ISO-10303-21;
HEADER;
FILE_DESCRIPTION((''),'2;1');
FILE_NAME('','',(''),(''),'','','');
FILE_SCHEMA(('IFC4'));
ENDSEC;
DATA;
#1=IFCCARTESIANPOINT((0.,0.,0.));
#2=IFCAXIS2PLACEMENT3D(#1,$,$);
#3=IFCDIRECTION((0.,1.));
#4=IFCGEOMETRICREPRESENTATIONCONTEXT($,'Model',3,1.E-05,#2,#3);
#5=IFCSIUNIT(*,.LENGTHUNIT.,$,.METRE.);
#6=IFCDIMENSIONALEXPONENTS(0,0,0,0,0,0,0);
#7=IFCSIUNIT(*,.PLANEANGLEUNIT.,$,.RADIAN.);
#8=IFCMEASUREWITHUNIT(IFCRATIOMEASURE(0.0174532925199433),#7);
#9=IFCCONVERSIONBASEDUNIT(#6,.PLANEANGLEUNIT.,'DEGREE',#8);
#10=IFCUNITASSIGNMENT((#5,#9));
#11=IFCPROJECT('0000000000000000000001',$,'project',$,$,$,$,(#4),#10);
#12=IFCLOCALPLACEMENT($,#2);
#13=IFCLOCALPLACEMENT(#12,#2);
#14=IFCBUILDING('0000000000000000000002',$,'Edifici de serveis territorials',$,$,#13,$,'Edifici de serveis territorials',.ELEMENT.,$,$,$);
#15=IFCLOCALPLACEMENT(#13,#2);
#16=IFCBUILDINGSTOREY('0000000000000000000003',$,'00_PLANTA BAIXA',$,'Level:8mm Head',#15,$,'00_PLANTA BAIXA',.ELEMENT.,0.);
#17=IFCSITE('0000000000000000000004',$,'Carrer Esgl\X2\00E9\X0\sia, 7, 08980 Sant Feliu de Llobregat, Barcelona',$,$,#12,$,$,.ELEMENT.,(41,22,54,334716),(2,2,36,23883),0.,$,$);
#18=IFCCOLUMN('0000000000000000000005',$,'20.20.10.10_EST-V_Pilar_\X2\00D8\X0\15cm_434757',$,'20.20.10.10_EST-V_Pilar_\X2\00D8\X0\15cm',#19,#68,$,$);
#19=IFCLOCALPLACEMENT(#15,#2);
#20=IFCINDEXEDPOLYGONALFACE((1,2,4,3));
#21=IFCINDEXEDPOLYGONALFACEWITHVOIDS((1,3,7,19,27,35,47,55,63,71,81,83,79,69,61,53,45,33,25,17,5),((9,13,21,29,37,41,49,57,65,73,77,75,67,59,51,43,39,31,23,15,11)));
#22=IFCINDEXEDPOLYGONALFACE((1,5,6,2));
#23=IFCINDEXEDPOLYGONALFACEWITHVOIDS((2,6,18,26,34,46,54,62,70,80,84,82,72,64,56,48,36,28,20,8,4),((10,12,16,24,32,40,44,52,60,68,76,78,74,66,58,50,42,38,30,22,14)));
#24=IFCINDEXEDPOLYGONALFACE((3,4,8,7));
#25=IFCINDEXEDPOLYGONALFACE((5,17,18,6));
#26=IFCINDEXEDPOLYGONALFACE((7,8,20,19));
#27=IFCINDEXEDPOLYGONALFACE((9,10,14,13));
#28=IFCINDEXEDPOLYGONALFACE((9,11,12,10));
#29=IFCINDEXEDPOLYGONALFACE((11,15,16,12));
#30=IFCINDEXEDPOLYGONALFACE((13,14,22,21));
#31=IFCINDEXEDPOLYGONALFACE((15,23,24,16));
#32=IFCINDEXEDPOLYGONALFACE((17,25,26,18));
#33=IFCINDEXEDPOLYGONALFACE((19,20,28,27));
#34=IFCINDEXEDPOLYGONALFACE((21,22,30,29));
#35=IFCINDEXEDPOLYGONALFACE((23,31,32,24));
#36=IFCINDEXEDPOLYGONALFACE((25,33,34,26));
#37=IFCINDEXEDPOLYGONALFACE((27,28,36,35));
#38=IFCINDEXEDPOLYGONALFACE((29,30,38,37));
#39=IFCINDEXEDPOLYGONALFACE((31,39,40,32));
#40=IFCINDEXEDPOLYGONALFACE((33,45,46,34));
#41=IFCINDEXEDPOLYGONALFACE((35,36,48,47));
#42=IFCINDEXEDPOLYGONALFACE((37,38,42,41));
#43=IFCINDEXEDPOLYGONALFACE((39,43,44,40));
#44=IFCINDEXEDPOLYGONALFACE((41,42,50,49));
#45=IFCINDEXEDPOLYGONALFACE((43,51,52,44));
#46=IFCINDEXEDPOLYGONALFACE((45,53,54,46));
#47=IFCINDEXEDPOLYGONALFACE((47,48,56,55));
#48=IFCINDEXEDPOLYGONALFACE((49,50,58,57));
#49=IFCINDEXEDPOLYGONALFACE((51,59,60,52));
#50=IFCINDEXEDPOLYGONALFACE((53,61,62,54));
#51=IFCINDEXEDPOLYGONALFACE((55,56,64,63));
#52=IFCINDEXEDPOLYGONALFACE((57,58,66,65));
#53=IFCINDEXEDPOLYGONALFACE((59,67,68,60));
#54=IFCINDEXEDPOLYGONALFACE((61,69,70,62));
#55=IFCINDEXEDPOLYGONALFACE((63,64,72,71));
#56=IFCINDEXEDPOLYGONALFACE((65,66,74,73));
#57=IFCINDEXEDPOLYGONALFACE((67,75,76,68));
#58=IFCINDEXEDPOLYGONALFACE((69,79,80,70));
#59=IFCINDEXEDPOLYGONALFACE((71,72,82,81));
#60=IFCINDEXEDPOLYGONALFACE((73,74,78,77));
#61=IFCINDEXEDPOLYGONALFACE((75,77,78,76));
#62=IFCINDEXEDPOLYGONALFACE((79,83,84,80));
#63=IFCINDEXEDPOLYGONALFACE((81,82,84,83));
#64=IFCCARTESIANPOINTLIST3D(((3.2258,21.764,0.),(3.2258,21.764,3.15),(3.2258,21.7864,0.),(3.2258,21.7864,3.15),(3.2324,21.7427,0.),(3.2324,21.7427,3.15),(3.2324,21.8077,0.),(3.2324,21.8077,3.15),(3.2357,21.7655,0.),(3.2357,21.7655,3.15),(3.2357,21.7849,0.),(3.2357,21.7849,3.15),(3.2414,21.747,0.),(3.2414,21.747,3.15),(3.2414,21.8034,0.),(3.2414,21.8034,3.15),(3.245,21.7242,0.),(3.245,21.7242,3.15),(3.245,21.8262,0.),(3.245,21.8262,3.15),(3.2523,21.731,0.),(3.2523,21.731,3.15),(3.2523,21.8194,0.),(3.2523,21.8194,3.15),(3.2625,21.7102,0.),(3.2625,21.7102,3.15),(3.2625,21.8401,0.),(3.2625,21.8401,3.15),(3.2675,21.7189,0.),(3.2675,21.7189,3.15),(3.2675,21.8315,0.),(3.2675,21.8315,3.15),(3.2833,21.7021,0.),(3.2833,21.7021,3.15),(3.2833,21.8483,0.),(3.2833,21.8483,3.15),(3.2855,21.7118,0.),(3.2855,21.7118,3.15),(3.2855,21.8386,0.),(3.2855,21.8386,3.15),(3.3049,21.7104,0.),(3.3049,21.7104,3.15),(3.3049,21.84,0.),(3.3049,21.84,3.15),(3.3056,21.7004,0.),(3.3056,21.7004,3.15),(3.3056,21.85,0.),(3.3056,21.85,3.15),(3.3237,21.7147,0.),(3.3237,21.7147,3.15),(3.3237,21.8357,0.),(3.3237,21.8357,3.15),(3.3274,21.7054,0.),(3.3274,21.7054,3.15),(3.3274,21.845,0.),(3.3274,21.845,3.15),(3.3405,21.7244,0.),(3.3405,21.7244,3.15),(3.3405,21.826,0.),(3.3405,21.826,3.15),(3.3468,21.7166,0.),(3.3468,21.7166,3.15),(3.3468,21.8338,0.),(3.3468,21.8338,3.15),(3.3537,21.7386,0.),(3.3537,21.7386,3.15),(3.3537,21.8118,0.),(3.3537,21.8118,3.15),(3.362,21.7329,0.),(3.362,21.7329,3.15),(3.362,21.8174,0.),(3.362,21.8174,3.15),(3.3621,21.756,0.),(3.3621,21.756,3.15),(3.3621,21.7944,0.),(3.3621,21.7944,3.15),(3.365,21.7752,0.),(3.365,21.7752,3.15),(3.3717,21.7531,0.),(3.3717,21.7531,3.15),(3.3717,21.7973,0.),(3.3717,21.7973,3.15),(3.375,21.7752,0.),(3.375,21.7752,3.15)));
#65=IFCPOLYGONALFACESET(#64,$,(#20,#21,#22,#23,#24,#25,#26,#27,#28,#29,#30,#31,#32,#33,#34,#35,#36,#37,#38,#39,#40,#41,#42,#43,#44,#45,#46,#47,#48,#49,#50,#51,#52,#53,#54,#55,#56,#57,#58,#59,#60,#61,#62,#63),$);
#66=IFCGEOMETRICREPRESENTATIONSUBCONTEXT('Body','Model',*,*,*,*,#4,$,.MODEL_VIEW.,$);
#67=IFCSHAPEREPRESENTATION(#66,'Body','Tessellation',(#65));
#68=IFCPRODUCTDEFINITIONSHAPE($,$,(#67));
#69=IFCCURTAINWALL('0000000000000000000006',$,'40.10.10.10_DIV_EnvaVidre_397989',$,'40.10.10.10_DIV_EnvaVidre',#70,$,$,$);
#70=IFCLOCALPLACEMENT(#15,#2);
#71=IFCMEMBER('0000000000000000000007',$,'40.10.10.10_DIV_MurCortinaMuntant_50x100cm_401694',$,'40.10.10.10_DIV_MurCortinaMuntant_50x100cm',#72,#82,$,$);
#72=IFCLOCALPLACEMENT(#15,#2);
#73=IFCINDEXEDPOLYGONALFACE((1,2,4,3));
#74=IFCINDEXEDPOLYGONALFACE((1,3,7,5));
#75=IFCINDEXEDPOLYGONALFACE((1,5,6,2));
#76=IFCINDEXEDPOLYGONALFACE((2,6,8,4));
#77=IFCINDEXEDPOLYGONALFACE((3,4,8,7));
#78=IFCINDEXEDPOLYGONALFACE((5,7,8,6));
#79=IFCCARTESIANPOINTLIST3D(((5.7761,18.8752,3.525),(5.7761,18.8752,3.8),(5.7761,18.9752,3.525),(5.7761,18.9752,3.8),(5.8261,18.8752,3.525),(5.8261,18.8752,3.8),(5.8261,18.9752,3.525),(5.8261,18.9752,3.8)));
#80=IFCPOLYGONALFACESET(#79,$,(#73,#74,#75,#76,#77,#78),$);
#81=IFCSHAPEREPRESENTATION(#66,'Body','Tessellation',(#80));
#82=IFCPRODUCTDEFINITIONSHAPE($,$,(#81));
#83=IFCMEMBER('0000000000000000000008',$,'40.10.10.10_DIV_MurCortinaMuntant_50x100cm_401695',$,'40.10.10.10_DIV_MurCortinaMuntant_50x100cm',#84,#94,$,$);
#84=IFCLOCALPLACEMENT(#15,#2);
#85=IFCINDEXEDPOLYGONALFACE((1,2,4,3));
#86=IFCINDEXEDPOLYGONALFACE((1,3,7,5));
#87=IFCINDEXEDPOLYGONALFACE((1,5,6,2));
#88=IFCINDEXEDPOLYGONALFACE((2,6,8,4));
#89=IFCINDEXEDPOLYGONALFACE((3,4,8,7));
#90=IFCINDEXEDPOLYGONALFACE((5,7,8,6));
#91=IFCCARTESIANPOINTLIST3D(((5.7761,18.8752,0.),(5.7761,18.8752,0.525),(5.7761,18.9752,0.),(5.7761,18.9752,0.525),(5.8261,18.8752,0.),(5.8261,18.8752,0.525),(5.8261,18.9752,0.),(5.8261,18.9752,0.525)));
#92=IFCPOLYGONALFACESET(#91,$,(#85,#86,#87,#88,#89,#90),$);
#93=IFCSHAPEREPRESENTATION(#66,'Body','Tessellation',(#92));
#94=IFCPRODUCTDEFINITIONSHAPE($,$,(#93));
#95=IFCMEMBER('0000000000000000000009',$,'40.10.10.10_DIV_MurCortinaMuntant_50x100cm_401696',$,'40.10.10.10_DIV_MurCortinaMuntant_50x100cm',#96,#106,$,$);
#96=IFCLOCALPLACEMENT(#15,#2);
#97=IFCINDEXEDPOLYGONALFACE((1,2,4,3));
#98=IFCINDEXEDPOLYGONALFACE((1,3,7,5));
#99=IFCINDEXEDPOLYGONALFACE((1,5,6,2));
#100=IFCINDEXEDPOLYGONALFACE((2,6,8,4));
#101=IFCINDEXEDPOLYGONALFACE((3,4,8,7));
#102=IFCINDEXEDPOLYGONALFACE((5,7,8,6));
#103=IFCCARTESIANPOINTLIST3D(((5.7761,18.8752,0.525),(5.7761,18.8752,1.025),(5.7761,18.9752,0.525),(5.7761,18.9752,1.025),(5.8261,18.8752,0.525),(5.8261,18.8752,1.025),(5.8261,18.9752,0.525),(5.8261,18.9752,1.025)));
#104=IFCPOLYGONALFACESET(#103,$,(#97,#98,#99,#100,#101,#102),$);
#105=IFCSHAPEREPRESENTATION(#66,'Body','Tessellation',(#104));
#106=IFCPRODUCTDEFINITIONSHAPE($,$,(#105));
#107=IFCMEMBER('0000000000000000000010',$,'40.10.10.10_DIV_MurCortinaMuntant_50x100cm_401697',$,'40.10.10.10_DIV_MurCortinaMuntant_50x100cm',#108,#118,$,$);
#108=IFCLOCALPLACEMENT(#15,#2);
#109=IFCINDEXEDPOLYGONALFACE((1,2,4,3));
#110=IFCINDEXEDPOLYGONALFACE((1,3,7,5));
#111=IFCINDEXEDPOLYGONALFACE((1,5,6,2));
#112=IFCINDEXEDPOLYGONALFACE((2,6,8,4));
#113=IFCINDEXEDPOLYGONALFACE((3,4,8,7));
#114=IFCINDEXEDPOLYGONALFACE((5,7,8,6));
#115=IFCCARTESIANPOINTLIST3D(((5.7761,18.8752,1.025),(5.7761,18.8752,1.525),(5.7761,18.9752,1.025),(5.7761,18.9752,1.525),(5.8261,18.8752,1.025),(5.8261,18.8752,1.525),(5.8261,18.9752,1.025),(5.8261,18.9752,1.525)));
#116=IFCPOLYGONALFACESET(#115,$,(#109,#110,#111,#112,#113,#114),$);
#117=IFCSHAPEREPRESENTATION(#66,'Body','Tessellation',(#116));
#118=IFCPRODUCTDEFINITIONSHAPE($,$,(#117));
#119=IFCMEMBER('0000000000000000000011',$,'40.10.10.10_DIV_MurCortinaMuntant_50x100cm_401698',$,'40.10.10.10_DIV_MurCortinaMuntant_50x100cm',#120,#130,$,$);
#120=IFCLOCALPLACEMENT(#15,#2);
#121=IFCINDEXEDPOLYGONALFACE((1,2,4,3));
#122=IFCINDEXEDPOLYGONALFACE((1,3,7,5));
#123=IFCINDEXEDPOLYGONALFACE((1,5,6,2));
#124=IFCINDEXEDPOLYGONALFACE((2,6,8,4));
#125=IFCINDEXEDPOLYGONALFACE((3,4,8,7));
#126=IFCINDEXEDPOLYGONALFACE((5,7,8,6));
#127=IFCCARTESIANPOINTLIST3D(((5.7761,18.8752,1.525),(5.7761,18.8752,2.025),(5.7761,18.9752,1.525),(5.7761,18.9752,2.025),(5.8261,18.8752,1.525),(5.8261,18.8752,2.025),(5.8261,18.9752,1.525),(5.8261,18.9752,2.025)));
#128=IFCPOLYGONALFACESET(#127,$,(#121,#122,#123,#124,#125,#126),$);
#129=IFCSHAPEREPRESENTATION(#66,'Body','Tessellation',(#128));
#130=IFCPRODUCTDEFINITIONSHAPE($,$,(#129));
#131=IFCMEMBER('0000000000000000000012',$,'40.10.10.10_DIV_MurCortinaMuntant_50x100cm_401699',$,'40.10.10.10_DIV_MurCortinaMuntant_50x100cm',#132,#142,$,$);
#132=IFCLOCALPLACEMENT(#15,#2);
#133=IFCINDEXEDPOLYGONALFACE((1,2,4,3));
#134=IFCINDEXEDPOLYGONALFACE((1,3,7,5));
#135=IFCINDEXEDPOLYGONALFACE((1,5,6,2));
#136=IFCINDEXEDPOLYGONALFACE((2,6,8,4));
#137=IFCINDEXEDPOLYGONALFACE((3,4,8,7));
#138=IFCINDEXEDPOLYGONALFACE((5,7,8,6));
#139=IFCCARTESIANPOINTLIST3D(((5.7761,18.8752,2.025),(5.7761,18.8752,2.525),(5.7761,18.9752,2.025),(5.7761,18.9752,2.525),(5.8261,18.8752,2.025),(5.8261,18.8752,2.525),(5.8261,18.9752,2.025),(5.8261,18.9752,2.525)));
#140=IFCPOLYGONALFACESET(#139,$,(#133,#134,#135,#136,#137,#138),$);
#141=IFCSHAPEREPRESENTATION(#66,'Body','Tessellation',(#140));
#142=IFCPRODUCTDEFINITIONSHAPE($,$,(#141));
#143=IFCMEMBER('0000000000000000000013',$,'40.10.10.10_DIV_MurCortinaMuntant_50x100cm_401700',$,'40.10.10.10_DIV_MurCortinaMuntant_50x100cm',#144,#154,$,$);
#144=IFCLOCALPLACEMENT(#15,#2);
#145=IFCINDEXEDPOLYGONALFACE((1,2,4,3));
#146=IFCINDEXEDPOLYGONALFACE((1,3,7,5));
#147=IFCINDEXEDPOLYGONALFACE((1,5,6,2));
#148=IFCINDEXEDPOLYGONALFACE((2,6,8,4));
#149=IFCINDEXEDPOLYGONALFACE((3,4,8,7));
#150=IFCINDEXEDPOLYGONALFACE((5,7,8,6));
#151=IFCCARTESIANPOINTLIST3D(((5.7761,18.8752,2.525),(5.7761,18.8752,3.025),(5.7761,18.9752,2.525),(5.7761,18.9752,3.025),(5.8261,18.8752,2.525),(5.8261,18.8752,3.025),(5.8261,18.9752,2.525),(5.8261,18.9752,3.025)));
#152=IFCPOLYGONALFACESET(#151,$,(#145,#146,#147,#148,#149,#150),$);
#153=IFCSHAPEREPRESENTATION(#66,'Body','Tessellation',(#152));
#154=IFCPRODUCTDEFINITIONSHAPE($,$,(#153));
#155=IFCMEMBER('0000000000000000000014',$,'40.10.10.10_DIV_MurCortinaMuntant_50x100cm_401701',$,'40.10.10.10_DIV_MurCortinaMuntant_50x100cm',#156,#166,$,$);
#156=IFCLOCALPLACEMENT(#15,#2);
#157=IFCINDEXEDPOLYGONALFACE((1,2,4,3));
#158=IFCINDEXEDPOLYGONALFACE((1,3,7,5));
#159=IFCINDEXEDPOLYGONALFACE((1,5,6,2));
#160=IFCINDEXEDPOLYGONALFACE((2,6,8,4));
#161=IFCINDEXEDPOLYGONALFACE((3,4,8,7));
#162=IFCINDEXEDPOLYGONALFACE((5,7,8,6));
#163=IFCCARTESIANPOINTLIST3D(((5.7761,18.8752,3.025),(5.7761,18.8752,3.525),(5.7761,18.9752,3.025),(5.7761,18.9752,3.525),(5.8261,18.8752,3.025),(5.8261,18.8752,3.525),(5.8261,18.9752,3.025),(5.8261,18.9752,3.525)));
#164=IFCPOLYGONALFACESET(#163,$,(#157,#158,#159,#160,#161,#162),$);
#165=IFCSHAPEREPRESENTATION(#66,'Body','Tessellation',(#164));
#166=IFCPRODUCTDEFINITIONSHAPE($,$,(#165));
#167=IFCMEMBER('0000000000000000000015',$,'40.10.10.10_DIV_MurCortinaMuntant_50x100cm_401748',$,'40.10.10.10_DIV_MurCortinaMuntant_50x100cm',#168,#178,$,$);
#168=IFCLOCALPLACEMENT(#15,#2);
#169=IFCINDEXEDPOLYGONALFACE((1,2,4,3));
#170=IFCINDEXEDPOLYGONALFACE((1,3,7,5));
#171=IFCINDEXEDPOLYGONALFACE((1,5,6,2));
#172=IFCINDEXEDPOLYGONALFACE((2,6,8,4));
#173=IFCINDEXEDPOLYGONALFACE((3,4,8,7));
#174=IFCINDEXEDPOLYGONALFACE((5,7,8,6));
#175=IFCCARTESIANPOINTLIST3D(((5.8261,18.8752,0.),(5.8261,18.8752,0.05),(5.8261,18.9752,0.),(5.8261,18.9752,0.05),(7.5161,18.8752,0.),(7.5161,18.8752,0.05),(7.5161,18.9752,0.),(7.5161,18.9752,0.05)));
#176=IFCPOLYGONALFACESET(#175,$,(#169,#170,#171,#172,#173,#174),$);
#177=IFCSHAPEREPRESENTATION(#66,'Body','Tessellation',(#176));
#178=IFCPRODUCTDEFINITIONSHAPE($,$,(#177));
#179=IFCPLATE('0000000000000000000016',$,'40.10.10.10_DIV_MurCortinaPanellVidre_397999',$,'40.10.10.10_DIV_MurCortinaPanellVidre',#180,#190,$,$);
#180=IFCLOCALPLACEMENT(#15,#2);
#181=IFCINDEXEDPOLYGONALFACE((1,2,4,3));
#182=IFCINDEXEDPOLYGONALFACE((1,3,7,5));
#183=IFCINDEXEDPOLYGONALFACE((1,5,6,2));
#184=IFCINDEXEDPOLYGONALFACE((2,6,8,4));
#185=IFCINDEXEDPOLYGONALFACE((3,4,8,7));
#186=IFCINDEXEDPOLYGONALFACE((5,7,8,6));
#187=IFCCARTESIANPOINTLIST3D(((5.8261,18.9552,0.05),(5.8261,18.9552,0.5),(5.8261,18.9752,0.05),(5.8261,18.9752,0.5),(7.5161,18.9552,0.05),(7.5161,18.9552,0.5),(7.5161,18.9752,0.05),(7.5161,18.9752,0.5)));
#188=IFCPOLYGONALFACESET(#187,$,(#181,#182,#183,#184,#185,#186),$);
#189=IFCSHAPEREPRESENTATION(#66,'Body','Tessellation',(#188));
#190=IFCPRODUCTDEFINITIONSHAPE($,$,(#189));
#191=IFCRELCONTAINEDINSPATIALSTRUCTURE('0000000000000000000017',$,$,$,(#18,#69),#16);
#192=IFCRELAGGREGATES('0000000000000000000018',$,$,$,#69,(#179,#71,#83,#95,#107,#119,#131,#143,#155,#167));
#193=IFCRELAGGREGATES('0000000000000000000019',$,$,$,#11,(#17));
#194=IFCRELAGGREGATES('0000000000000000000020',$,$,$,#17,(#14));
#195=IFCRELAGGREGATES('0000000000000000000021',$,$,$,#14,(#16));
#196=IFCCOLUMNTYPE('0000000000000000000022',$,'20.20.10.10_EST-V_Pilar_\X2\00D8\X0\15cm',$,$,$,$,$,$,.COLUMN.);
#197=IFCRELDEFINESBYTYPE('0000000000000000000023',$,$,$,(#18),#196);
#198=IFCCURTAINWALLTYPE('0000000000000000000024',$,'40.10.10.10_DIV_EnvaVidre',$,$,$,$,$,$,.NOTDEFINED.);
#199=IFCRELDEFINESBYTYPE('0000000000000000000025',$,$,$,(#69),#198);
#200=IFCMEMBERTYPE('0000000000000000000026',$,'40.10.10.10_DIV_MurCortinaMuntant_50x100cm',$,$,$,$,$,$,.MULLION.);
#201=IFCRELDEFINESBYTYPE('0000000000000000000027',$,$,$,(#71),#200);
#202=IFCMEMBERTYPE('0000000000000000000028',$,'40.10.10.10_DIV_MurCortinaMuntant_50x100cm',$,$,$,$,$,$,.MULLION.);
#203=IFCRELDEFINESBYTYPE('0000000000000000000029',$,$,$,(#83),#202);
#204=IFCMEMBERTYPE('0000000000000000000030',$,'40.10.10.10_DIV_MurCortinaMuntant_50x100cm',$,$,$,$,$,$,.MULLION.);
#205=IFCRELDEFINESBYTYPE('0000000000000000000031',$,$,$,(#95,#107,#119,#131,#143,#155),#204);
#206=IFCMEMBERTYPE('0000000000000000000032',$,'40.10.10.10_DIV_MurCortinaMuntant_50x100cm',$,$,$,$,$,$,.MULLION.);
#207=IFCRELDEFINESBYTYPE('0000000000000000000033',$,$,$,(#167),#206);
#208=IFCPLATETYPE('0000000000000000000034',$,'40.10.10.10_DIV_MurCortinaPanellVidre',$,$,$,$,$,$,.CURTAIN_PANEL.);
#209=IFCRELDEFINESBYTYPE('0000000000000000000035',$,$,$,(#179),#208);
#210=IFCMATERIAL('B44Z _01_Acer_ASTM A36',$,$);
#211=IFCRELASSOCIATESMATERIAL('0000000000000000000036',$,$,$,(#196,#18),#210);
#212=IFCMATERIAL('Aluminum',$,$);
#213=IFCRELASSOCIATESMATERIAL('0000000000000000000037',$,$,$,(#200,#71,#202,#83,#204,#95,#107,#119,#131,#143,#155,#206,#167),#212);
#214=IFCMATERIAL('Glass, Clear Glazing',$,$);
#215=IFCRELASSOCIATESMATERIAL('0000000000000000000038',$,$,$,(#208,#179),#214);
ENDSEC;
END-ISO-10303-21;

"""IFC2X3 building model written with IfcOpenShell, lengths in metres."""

from ifc_helpers import new_model, entity, si_unit, converted_unit, direction, frame, frame_2d, origin, origin_2d_with_axis, place, context, subcontext, project, spatial, rectangle, hollow_circle, extrude, source, transform, mapped, material, type_object, type_shapes, element, aggregate, save


model = new_model("IFC2X3")

# Units and contexts
model_context = context("Model", 3, precision=1e-05, world=origin(), true_north=direction((0.0, 1.0)))
body_context = subcontext(model_context, "Body", "Model", "MODEL_VIEW")
ifc_project = project(units=[si_unit("LENGTHUNIT", "METRE"), converted_unit("PLANEANGLEUNIT", "DEGREE", entity("IfcRatioMeasure", 0.0174532925199433), si_unit("PLANEANGLEUNIT", "RADIAN"), dimensions=[0, 0, 0, 0, 0, 0, 0])], contexts=[model_context])

# Site, building, storey
site_placement = place(None, origin())
site = spatial("IfcSite", under=ifc_project, at=site_placement, Name="Carrer Església, 7, 08980 Sant Feliu de Llobregat, Barcelona", CompositionType="ELEMENT", RefLatitude=(41, 22, 54, 334716), RefLongitude=(2, 2, 36, 23883), RefElevation=0.0)
building_placement = place(site_placement, origin())
building = spatial("IfcBuilding", under=site, at=building_placement, Name="Edifici de serveis territorials", LongName="Edifici de serveis territorials", CompositionType="ELEMENT")
storey_placement = place(building_placement, origin())
storey = spatial("IfcBuildingStorey", under=building, at=storey_placement, Name="00_PLANTA BAIXA", ObjectType="Level:8mm Head", LongName="00_PLANTA BAIXA", CompositionType="ELEMENT", Elevation=0.0)

# Column
ifc_material_1 = material(Name="B44Z _01_Acer_ASTM A36")
column_type = type_object("IfcColumnType", Name="20.20.10.10_EST-V_Pilar_Ø15cm", PredefinedType="COLUMN", material=ifc_material_1)
shared_shape_1 = source(origin(), body_context, "Body", "SweptSolid", [
    extrude(hollow_circle(Radius=0.075, WallThickness=0.01, at=frame_2d((0.0, 0.0), x_axis=(1.0, 0.0))), origin(), (0.0, 0.0, 1.0), 3.15),
])
type_shapes(column_type, [shared_shape_1])
column_placement = place(storey_placement, frame((3.3, 21.7752, 0.0)))
element("IfcColumn", 1, at=column_placement, inside=storey, type_object=column_type, material=ifc_material_1, Name="20.20.10.10_EST-V_Pilar_Ø15cm_434757", ObjectType="20.20.10.10_EST-V_Pilar_Ø15cm", context=body_context, shape_type="MappedRepresentation", body=[
    mapped(shared_shape_1, transform((0.0, 0.0, 0.0), scale=1.0)),
])

# Curtain wall, members, plate
curtain_wall_type = type_object("IfcCurtainWallType", Name="40.10.10.10_DIV_EnvaVidre", PredefinedType="NOTDEFINED")
curtain_wall_placement = place(storey_placement, origin())
curtain_wall = element("IfcCurtainWall", 2, at=curtain_wall_placement, inside=storey, type_object=curtain_wall_type, Name="40.10.10.10_DIV_EnvaVidre_397989", ObjectType="40.10.10.10_DIV_EnvaVidre")
ifc_material_2 = material(Name="Aluminum")
member_type_1 = type_object("IfcMemberType", Name="40.10.10.10_DIV_MurCortinaMuntant_50x100cm", PredefinedType="MULLION", material=ifc_material_2)
shared_shape_2 = source(origin(), body_context, "Body", "SweptSolid", [
    extrude(rectangle(XDim=0.1, YDim=0.05, at=origin_2d_with_axis()), frame((-0.025, 0.0, -0.275), z_axis=(0.0, 0.0, 1.0), x_axis=(0.0, -1.0, 0.0)), (0.0, 0.0, 1.0), 0.275),
])
type_shapes(member_type_1, [shared_shape_2])
member_1_placement = place(storey_placement, frame((5.7761, 18.9252, 3.8), z_axis=(0.0, 0.0, 1.0), x_axis=(-1.0, 0.0, 0.0)))
member_1 = element("IfcMember", 3, at=member_1_placement, type_object=member_type_1, material=ifc_material_2, Name="40.10.10.10_DIV_MurCortinaMuntant_50x100cm_401694", ObjectType="40.10.10.10_DIV_MurCortinaMuntant_50x100cm", context=body_context, shape_type="MappedRepresentation", body=[
    mapped(shared_shape_2, transform((0.0, 0.0, 0.0), scale=1.0)),
])
member_type_2 = type_object("IfcMemberType", Name="40.10.10.10_DIV_MurCortinaMuntant_50x100cm", PredefinedType="MULLION", material=ifc_material_2)
shared_shape_3 = source(origin(), body_context, "Body", "SweptSolid", [
    extrude(rectangle(XDim=0.1, YDim=0.05, at=origin_2d_with_axis()), frame((-0.025, 0.0, -0.525), z_axis=(0.0, 0.0, 1.0), x_axis=(0.0, -1.0, 0.0)), (0.0, 0.0, 1.0), 0.525),
])
type_shapes(member_type_2, [shared_shape_3])
member_2_placement = place(storey_placement, frame((5.7761, 18.9252, 0.525), z_axis=(0.0, 0.0, 1.0), x_axis=(-1.0, 0.0, 0.0)))
member_2 = element("IfcMember", 4, at=member_2_placement, type_object=member_type_2, material=ifc_material_2, Name="40.10.10.10_DIV_MurCortinaMuntant_50x100cm_401695", ObjectType="40.10.10.10_DIV_MurCortinaMuntant_50x100cm", context=body_context, shape_type="MappedRepresentation", body=[
    mapped(shared_shape_3, transform((0.0, 0.0, 0.0), scale=1.0)),
])
member_type_3 = type_object("IfcMemberType", Name="40.10.10.10_DIV_MurCortinaMuntant_50x100cm", PredefinedType="MULLION", material=ifc_material_2)
shared_shape_4 = source(origin(), body_context, "Body", "SweptSolid", [
    extrude(rectangle(XDim=0.1, YDim=0.05, at=origin_2d_with_axis()), frame((-0.025, 0.0, -0.5), z_axis=(0.0, 0.0, 1.0), x_axis=(0.0, -1.0, 0.0)), (0.0, 0.0, 1.0), 0.5),
])
type_shapes(member_type_3, [shared_shape_4])
member_3_placement = place(storey_placement, frame((5.7761, 18.9252, 1.025), z_axis=(0.0, 0.0, 1.0), x_axis=(-1.0, 0.0, 0.0)))
member_3 = element("IfcMember", 5, at=member_3_placement, type_object=member_type_3, material=ifc_material_2, Name="40.10.10.10_DIV_MurCortinaMuntant_50x100cm_401696", ObjectType="40.10.10.10_DIV_MurCortinaMuntant_50x100cm", context=body_context, shape_type="MappedRepresentation", body=[
    mapped(shared_shape_4, transform((0.0, 0.0, 0.0), scale=1.0)),
])
member_4_placement = place(storey_placement, frame((5.7761, 18.9252, 1.525), z_axis=(0.0, 0.0, 1.0), x_axis=(-1.0, 0.0, 0.0)))
member_4 = element("IfcMember", 6, at=member_4_placement, type_object=member_type_3, material=ifc_material_2, Name="40.10.10.10_DIV_MurCortinaMuntant_50x100cm_401697", ObjectType="40.10.10.10_DIV_MurCortinaMuntant_50x100cm", context=body_context, shape_type="MappedRepresentation", body=[
    mapped(shared_shape_4, transform((0.0, 0.0, 0.0), scale=1.0)),
])
member_5_placement = place(storey_placement, frame((5.7761, 18.9252, 2.025), z_axis=(0.0, 0.0, 1.0), x_axis=(-1.0, 0.0, 0.0)))
member_5 = element("IfcMember", 7, at=member_5_placement, type_object=member_type_3, material=ifc_material_2, Name="40.10.10.10_DIV_MurCortinaMuntant_50x100cm_401698", ObjectType="40.10.10.10_DIV_MurCortinaMuntant_50x100cm", context=body_context, shape_type="MappedRepresentation", body=[
    mapped(shared_shape_4, transform((0.0, 0.0, 0.0), scale=1.0)),
])
member_6_placement = place(storey_placement, frame((5.7761, 18.9252, 2.525), z_axis=(0.0, 0.0, 1.0), x_axis=(-1.0, 0.0, 0.0)))
member_6 = element("IfcMember", 8, at=member_6_placement, type_object=member_type_3, material=ifc_material_2, Name="40.10.10.10_DIV_MurCortinaMuntant_50x100cm_401699", ObjectType="40.10.10.10_DIV_MurCortinaMuntant_50x100cm", context=body_context, shape_type="MappedRepresentation", body=[
    mapped(shared_shape_4, transform((0.0, 0.0, 0.0), scale=1.0)),
])
member_7_placement = place(storey_placement, frame((5.7761, 18.9252, 3.025), z_axis=(0.0, 0.0, 1.0), x_axis=(-1.0, 0.0, 0.0)))
member_7 = element("IfcMember", 9, at=member_7_placement, type_object=member_type_3, material=ifc_material_2, Name="40.10.10.10_DIV_MurCortinaMuntant_50x100cm_401700", ObjectType="40.10.10.10_DIV_MurCortinaMuntant_50x100cm", context=body_context, shape_type="MappedRepresentation", body=[
    mapped(shared_shape_4, transform((0.0, 0.0, 0.0), scale=1.0)),
])
member_8_placement = place(storey_placement, frame((5.7761, 18.9252, 3.525), z_axis=(0.0, 0.0, 1.0), x_axis=(-1.0, 0.0, 0.0)))
member_8 = element("IfcMember", 10, at=member_8_placement, type_object=member_type_3, material=ifc_material_2, Name="40.10.10.10_DIV_MurCortinaMuntant_50x100cm_401701", ObjectType="40.10.10.10_DIV_MurCortinaMuntant_50x100cm", context=body_context, shape_type="MappedRepresentation", body=[
    mapped(shared_shape_4, transform((0.0, 0.0, 0.0), scale=1.0)),
])
member_type_4 = type_object("IfcMemberType", Name="40.10.10.10_DIV_MurCortinaMuntant_50x100cm", PredefinedType="MULLION", material=ifc_material_2)
shared_shape_5 = source(origin(), body_context, "Body", "SweptSolid", [
    extrude(rectangle(XDim=0.1, YDim=0.05, at=origin_2d_with_axis()), frame((-0.025, 0.0, -1.69), z_axis=(0.0, 0.0, 1.0), x_axis=(0.0, -1.0, 0.0)), (0.0, 0.0, 1.0), 1.69),
])
type_shapes(member_type_4, [shared_shape_5])
member_9_placement = place(storey_placement, frame((5.8261, 18.9252, 0.0), z_axis=(-1.0, 0.0, 0.0), x_axis=(0.0, 0.0, -1.0)))
member_9 = element("IfcMember", 11, at=member_9_placement, type_object=member_type_4, material=ifc_material_2, Name="40.10.10.10_DIV_MurCortinaMuntant_50x100cm_401748", ObjectType="40.10.10.10_DIV_MurCortinaMuntant_50x100cm", context=body_context, shape_type="MappedRepresentation", body=[
    mapped(shared_shape_5, transform((0.0, 0.0, 0.0), scale=1.0)),
])
ifc_material_3 = material(Name="Glass, Clear Glazing")
plate_type = type_object("IfcPlateType", Name="40.10.10.10_DIV_MurCortinaPanellVidre", PredefinedType="CURTAIN_PANEL", material=ifc_material_3)
shared_shape_6 = source(origin(), body_context, "Body", "SweptSolid", [
    extrude(rectangle(XDim=0.02, YDim=1.69, at=frame_2d((0.0, 0.0), x_axis=(1.0, 0.0))), frame((0.845, 0.01, 0.0), z_axis=(0.0, 0.0, 1.0), x_axis=(0.0, 1.0, 0.0)), (0.0, 0.0, 1.0), 0.45),
])
type_shapes(plate_type, [shared_shape_6])
plate_1_placement = place(curtain_wall_placement, frame((5.8261, 18.9552, 0.05)))
plate_1 = element("IfcPlate", 12, at=plate_1_placement, type_object=plate_type, material=ifc_material_3, Name="40.10.10.10_DIV_MurCortinaPanellVidre_397999", ObjectType="40.10.10.10_DIV_MurCortinaPanellVidre", context=body_context, shape_type="MappedRepresentation", body=[
    mapped(shared_shape_6, transform((0.0, 0.0, 0.0), scale=1.0)),
])
aggregate(curtain_wall, [plate_1, member_1, member_2, member_3, member_4, member_5, member_6, member_7, member_8, member_9])

save(model, "model.ifc")
